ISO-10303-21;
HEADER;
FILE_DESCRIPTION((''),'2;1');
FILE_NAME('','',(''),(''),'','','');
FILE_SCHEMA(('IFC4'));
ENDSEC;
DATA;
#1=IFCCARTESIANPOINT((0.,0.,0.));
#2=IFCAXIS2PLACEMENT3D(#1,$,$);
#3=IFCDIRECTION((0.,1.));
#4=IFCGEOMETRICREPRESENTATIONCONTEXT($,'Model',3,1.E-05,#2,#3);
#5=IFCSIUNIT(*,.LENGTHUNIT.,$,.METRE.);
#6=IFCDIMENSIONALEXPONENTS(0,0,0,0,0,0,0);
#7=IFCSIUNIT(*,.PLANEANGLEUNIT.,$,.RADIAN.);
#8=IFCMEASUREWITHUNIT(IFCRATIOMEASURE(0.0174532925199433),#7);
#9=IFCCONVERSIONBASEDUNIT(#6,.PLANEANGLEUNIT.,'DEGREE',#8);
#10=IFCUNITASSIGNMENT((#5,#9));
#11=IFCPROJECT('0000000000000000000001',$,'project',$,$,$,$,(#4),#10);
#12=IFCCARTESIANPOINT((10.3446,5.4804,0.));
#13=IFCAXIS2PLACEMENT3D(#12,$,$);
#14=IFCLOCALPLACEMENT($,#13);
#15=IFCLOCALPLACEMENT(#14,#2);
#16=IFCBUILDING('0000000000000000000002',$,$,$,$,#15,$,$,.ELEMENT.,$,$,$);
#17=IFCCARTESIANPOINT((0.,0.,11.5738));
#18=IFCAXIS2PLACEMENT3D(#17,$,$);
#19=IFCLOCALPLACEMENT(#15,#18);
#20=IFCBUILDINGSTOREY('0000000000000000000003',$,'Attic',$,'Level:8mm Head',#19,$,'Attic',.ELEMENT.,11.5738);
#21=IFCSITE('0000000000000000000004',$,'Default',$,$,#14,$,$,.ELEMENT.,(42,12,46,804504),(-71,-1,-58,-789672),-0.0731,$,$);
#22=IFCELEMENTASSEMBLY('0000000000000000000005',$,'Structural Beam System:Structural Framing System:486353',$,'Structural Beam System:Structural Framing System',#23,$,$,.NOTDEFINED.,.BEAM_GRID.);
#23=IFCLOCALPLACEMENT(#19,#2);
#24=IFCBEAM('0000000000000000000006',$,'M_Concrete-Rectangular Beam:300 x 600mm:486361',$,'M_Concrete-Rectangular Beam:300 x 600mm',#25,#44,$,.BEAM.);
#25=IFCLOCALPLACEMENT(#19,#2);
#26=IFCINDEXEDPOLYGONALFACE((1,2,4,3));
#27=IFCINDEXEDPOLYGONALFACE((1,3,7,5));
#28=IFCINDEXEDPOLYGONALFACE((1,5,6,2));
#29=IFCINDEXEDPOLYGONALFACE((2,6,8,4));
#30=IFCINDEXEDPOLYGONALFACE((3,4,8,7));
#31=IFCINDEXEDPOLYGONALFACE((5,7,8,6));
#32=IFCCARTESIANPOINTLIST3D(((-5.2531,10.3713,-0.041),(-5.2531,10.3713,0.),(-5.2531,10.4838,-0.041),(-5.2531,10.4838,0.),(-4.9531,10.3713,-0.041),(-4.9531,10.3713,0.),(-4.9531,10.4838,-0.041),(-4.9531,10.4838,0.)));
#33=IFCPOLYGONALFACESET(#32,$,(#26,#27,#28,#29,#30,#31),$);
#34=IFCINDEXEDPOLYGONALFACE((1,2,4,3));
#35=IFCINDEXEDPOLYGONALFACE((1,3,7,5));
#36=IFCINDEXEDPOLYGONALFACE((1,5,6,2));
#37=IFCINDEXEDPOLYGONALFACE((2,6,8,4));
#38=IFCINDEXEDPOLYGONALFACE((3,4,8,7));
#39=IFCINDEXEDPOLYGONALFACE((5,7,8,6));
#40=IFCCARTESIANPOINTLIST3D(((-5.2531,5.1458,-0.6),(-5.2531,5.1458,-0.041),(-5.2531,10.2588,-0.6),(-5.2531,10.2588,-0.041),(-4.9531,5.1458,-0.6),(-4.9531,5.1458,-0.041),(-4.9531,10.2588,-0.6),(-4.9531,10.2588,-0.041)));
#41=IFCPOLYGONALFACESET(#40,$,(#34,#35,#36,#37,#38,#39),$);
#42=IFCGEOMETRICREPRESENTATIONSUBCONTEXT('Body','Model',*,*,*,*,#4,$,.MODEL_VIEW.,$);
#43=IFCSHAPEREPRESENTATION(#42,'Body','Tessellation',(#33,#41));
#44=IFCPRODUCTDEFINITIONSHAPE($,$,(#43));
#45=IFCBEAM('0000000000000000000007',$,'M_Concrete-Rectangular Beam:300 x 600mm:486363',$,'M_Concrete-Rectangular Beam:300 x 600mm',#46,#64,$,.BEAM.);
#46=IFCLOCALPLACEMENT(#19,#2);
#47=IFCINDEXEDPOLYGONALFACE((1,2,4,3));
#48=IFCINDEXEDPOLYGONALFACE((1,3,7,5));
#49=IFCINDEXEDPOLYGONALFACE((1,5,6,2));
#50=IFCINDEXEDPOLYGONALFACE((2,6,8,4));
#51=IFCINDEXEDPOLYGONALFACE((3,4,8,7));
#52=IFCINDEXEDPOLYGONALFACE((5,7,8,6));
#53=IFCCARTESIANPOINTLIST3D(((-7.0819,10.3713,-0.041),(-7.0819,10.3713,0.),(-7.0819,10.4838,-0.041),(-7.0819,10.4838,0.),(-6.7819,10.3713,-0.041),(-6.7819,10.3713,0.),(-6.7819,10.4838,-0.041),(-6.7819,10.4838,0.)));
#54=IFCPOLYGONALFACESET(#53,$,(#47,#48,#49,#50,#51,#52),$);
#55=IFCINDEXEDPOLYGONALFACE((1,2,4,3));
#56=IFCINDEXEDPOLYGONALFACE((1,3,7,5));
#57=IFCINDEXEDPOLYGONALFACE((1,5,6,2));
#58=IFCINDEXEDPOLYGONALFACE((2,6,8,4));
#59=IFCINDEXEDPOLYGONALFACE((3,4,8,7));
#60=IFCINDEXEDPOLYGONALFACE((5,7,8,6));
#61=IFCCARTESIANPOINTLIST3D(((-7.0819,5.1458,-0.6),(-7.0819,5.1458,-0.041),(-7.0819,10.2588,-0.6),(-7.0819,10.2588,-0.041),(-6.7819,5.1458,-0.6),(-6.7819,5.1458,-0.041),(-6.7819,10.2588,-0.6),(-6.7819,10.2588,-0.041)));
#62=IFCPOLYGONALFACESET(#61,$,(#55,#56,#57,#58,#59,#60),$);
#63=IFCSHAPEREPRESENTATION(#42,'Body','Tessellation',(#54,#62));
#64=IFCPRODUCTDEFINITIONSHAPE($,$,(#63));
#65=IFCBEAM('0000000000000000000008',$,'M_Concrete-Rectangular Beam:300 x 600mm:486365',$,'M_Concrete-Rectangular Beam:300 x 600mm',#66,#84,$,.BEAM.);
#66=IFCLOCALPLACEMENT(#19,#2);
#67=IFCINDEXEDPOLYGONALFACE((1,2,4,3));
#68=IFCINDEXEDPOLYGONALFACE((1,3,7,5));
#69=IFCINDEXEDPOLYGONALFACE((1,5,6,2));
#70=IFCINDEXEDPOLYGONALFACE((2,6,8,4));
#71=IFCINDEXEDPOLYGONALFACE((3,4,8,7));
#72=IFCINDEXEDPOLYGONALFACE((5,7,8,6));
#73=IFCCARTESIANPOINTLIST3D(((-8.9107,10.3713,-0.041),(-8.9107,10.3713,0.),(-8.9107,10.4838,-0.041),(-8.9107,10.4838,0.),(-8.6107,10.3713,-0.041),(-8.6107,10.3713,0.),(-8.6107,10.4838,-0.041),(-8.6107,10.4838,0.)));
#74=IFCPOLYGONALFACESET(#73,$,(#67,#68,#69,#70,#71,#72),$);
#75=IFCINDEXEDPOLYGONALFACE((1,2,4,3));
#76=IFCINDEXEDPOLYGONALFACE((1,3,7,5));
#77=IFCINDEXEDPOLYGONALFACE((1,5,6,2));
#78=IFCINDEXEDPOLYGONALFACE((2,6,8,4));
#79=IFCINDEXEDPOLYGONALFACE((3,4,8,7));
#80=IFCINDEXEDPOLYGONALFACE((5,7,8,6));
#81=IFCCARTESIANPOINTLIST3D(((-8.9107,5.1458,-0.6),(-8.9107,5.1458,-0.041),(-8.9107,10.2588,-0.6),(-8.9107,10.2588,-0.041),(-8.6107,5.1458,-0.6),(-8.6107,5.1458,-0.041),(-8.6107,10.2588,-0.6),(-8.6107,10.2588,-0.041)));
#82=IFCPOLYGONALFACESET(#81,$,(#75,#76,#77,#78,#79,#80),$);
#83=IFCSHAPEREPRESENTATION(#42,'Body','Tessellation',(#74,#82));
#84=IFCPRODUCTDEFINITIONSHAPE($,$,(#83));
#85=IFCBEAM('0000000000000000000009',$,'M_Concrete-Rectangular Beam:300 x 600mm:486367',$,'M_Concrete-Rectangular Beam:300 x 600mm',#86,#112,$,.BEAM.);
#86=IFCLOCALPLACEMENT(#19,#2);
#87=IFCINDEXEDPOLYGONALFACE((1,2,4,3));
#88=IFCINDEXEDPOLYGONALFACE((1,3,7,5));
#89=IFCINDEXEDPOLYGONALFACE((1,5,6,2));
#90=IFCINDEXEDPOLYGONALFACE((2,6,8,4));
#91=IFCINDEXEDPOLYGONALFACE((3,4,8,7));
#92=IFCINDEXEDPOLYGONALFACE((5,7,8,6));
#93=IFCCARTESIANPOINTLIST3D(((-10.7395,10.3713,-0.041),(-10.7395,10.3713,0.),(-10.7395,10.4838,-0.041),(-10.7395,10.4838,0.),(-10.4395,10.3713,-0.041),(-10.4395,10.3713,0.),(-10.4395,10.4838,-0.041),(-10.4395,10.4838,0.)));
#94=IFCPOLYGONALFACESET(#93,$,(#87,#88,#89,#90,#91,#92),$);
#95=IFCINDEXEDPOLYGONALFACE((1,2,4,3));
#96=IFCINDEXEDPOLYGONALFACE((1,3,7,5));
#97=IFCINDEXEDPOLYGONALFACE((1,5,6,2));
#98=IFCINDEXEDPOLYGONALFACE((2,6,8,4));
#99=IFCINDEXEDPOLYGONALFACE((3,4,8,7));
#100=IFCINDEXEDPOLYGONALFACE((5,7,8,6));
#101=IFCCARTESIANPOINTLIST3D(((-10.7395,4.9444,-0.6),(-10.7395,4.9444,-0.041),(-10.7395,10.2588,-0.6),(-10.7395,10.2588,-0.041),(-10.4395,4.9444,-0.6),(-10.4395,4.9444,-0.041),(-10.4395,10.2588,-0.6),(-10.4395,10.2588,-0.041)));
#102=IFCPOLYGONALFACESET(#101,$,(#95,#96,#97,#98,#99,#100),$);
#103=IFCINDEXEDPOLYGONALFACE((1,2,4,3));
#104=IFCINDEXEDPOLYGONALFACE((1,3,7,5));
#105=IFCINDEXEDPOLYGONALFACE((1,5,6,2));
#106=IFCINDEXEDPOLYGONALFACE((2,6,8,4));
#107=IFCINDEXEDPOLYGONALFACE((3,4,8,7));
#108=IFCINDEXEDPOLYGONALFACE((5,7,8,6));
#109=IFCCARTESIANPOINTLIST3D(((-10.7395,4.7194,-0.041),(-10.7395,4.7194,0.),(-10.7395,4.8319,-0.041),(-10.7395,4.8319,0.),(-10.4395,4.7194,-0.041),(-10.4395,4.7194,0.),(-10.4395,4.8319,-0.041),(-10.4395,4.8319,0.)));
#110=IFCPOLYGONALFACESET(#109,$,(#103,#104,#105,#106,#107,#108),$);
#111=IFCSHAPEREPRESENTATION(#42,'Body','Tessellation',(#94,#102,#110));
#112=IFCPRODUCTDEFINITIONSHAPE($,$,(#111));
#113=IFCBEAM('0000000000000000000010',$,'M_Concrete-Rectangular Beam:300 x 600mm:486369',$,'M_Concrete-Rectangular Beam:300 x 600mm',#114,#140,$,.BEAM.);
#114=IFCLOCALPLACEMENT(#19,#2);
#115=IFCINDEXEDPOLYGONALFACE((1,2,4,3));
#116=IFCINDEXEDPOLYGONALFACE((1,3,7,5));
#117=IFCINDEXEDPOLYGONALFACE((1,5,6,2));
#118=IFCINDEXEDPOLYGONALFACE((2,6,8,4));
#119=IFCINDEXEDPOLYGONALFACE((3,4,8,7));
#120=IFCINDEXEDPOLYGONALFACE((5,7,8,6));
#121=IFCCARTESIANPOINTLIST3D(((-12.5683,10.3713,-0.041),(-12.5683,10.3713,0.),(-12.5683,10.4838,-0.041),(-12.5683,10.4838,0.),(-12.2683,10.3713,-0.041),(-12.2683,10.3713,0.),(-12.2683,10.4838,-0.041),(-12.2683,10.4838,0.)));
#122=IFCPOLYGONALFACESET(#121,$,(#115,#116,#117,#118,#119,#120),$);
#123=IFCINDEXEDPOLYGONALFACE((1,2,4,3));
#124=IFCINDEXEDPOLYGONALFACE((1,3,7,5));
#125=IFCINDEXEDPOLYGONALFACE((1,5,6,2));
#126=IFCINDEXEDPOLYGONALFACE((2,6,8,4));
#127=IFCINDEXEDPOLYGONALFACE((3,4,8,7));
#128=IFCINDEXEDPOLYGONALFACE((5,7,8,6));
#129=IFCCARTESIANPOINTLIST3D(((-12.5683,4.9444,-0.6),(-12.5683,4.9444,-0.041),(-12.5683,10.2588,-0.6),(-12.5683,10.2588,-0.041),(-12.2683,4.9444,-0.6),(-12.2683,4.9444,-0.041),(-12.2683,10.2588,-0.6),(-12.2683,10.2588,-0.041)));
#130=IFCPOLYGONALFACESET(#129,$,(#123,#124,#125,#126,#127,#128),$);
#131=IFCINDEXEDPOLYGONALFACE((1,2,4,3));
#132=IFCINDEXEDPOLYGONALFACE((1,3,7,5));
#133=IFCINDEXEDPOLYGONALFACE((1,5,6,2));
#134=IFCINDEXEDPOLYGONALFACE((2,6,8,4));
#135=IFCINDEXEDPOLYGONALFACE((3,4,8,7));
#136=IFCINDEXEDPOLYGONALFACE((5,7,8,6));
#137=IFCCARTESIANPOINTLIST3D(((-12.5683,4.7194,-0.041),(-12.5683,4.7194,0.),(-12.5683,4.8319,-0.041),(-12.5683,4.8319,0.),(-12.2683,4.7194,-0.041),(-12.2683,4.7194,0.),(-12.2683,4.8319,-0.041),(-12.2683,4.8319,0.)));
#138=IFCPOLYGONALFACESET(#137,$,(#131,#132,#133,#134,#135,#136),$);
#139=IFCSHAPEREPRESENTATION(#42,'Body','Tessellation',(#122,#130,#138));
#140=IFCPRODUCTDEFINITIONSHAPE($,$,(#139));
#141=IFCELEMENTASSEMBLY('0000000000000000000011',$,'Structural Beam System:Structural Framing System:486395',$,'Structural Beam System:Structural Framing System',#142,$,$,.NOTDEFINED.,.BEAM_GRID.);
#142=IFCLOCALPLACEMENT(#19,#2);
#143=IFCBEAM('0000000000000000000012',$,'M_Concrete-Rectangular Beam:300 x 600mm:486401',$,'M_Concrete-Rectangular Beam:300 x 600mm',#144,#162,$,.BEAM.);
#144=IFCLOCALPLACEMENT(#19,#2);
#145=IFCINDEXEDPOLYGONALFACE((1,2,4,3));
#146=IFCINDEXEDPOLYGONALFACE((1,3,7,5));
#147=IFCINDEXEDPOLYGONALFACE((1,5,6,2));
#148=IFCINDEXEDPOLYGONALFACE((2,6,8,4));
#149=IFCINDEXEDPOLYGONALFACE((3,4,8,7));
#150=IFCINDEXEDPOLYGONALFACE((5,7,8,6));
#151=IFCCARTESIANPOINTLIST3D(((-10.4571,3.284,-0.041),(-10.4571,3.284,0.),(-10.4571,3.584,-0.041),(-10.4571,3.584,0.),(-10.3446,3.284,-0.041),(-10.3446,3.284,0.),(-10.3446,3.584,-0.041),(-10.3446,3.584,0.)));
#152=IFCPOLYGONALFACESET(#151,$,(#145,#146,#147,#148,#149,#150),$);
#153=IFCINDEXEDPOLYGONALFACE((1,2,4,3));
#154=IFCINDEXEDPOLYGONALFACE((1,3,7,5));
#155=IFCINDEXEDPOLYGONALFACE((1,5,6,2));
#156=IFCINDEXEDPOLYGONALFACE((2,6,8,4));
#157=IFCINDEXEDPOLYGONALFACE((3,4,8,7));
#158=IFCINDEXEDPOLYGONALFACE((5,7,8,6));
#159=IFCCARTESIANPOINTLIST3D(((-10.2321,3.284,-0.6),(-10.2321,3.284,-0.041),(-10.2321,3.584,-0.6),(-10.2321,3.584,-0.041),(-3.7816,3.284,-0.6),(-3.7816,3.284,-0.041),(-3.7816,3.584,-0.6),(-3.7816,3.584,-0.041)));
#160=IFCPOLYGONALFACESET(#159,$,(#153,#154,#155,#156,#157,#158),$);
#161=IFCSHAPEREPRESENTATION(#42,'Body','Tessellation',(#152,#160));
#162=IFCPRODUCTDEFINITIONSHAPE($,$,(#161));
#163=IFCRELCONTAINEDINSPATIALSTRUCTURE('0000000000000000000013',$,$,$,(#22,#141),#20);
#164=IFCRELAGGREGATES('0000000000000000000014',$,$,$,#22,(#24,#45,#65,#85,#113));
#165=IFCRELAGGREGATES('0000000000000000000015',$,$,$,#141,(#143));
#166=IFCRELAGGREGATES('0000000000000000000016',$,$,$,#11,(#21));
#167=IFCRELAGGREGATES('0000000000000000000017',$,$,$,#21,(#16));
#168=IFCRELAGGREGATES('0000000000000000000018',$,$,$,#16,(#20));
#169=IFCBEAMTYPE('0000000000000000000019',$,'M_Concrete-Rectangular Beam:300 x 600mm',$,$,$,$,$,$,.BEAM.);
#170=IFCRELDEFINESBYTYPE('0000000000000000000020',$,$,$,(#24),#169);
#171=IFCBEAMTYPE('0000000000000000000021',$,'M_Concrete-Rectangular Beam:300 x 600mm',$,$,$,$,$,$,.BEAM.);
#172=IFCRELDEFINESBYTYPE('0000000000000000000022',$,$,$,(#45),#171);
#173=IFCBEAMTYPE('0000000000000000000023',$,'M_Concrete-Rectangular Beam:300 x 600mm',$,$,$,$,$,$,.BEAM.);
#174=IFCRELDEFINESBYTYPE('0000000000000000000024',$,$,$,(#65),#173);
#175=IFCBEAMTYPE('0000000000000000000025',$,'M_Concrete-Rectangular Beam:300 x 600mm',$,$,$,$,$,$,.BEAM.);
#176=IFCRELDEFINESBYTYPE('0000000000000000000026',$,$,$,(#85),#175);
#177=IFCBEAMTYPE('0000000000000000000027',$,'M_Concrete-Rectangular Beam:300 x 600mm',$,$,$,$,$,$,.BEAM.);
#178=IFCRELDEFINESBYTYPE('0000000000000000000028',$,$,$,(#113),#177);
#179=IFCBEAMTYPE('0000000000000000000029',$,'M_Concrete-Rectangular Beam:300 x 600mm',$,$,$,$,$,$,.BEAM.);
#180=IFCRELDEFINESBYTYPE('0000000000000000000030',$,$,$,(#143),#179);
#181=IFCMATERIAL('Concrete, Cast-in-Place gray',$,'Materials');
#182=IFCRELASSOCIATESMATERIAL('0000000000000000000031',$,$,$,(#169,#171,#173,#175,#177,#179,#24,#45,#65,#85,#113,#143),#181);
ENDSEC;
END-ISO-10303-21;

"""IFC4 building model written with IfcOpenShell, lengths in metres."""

from ifc_helpers import new_model, entity, si_unit, converted_unit, direction, frame, frame_2d, origin, place, context, subcontext, project, spatial, rectangle, extrude, source, transform, mapped, material, material_profile, profile_set, profile_usage, type_object, type_shapes, element, aggregate, save


model = new_model("IFC4")

# Units and contexts
model_context = context("Model", 3, precision=1e-05, world=origin(), true_north=direction((0.0, 1.0)))
body_context = subcontext(model_context, "Body", "Model", "MODEL_VIEW")
ifc_project = project(units=[si_unit("LENGTHUNIT", "METRE"), converted_unit("PLANEANGLEUNIT", "DEGREE", entity("IfcRatioMeasure", 0.0174532925199433), si_unit("PLANEANGLEUNIT", "RADIAN"), dimensions=[0, 0, 0, 0, 0, 0, 0])], contexts=[model_context])

# Site, building, storey
site_placement = place(None, frame((10.3446, 5.4804, 0.0)))
site = spatial("IfcSite", under=ifc_project, at=site_placement, Name="Default", CompositionType="ELEMENT", RefLatitude=(42, 12, 46, 804504), RefLongitude=(-71, -1, -58, -789672), RefElevation=-0.0731)
building_placement = place(site_placement, origin())
building = spatial("IfcBuilding", under=site, at=building_placement, CompositionType="ELEMENT")
storey_placement = place(building_placement, frame((0.0, 0.0, 11.5738)))
storey = spatial("IfcBuildingStorey", under=building, at=storey_placement, Name="Attic", ObjectType="Level:8mm Head", LongName="Attic", CompositionType="ELEMENT", Elevation=11.5738)

# Element assemblies, beams
assembly_1_placement = place(storey_placement, origin())
assembly_1 = element("IfcElementAssembly", 1, at=assembly_1_placement, inside=storey, Name="Structural Beam System:Structural Framing System:486353", ObjectType="Structural Beam System:Structural Framing System", AssemblyPlace="NOTDEFINED", PredefinedType="BEAM_GRID")
ifc_material_1 = material(Name="Concrete, Cast-in-Place gray", Category="Materials")
ifc_material_profile = material_profile(ifc_material_1, rectangle(XDim=0.559, YDim=0.3, at=frame_2d((0.0, 0.0), x_axis=(1.0, 0.0))), Name="300 x 600mm")
ifc_profile_set = profile_set([ifc_material_profile], Name="300 x 600mm")
ifc_profile_usage_1 = profile_usage(ifc_profile_set, cardinal=8)
beam_type_1 = type_object("IfcBeamType", Name="M_Concrete-Rectangular Beam:300 x 600mm", PredefinedType="BEAM", material=ifc_profile_set)
shared_shape_1 = source(origin(), body_context, "Body", "SweptSolid", [
    extrude(rectangle(XDim=0.041, YDim=0.3, at=frame_2d((0.0, 0.0), x_axis=(0.0, 1.0))), frame((-5.1031, 10.4838, 11.5533), z_axis=(0.0, -1.0, 0.0), x_axis=(-1.0, 0.0, 0.0)), (0.0, 0.0, 1.0), 0.1125),
    extrude(rectangle(XDim=0.559, YDim=0.3, at=frame_2d((0.0, 0.0), x_axis=(0.0, 1.0))), frame((-5.1031, 10.2588, 11.2533), z_axis=(0.0, -1.0, 0.0), x_axis=(-1.0, 0.0, 0.0)), (0.0, 0.0, 1.0), 5.113),
])
type_shapes(beam_type_1, [shared_shape_1])
beam_1_placement = place(assembly_1_placement, frame((0.0, 0.0, -11.5738)))
beam_1 = element("IfcBeam", 2, at=beam_1_placement, type_object=beam_type_1, material=ifc_profile_usage_1, Name="M_Concrete-Rectangular Beam:300 x 600mm:486361", ObjectType="M_Concrete-Rectangular Beam:300 x 600mm", PredefinedType="BEAM", context=body_context, shape_type="MappedRepresentation", body=[
    mapped(shared_shape_1, transform((0.0, 0.0, 0.0), scale=1.0)),
])
ifc_profile_usage_2 = profile_usage(ifc_profile_set, cardinal=8)
beam_type_2 = type_object("IfcBeamType", Name="M_Concrete-Rectangular Beam:300 x 600mm", PredefinedType="BEAM", material=ifc_profile_set)
shared_shape_2 = source(origin(), body_context, "Body", "SweptSolid", [
    extrude(rectangle(XDim=0.041, YDim=0.3, at=frame_2d((0.0, 0.0), x_axis=(0.0, 1.0))), frame((-6.9319, 10.4838, 11.5533), z_axis=(0.0, -1.0, 0.0), x_axis=(-1.0, 0.0, 0.0)), (0.0, 0.0, 1.0), 0.1125),
    extrude(rectangle(XDim=0.559, YDim=0.3, at=frame_2d((0.0, 0.0), x_axis=(0.0, 1.0))), frame((-6.9319, 10.2588, 11.2533), z_axis=(0.0, -1.0, 0.0), x_axis=(-1.0, 0.0, 0.0)), (0.0, 0.0, 1.0), 5.113),
])
type_shapes(beam_type_2, [shared_shape_2])
beam_2_placement = place(assembly_1_placement, frame((0.0, 0.0, -11.5738)))
beam_2 = element("IfcBeam", 3, at=beam_2_placement, type_object=beam_type_2, material=ifc_profile_usage_2, Name="M_Concrete-Rectangular Beam:300 x 600mm:486363", ObjectType="M_Concrete-Rectangular Beam:300 x 600mm", PredefinedType="BEAM", context=body_context, shape_type="MappedRepresentation", body=[
    mapped(shared_shape_2, transform((0.0, 0.0, 0.0), scale=1.0)),
])
ifc_profile_usage_3 = profile_usage(ifc_profile_set, cardinal=8)
beam_type_3 = type_object("IfcBeamType", Name="M_Concrete-Rectangular Beam:300 x 600mm", PredefinedType="BEAM", material=ifc_profile_set)
shared_shape_3 = source(origin(), body_context, "Body", "SweptSolid", [
    extrude(rectangle(XDim=0.041, YDim=0.3, at=frame_2d((0.0, 0.0), x_axis=(0.0, 1.0))), frame((-8.7607, 10.4838, 11.5533), z_axis=(0.0, -1.0, 0.0), x_axis=(-1.0, 0.0, 0.0)), (0.0, 0.0, 1.0), 0.1125),
    extrude(rectangle(XDim=0.559, YDim=0.3, at=frame_2d((0.0, 0.0), x_axis=(0.0, 1.0))), frame((-8.7607, 10.2588, 11.2533), z_axis=(0.0, -1.0, 0.0), x_axis=(-1.0, 0.0, 0.0)), (0.0, 0.0, 1.0), 5.113),
])
type_shapes(beam_type_3, [shared_shape_3])
beam_3_placement = place(assembly_1_placement, frame((0.0, 0.0, -11.5738)))
beam_3 = element("IfcBeam", 4, at=beam_3_placement, type_object=beam_type_3, material=ifc_profile_usage_3, Name="M_Concrete-Rectangular Beam:300 x 600mm:486365", ObjectType="M_Concrete-Rectangular Beam:300 x 600mm", PredefinedType="BEAM", context=body_context, shape_type="MappedRepresentation", body=[
    mapped(shared_shape_3, transform((0.0, 0.0, 0.0), scale=1.0)),
])
ifc_profile_usage_4 = profile_usage(ifc_profile_set, cardinal=8)
beam_type_4 = type_object("IfcBeamType", Name="M_Concrete-Rectangular Beam:300 x 600mm", PredefinedType="BEAM", material=ifc_profile_set)
shared_shape_4 = source(origin(), body_context, "Body", "SweptSolid", [
    extrude(rectangle(XDim=0.041, YDim=0.3, at=frame_2d((0.0, 0.0), x_axis=(0.0, 1.0))), frame((-10.5895, 10.4838, 11.5533), z_axis=(0.0, -1.0, 0.0), x_axis=(-1.0, 0.0, 0.0)), (0.0, 0.0, 1.0), 0.1125),
    extrude(rectangle(XDim=0.559, YDim=0.3, at=frame_2d((0.0, 0.0), x_axis=(0.0, 1.0))), frame((-10.5895, 10.2588, 11.2533), z_axis=(0.0, -1.0, 0.0), x_axis=(-1.0, 0.0, 0.0)), (0.0, 0.0, 1.0), 5.3144),
    extrude(rectangle(XDim=0.041, YDim=0.3, at=frame_2d((0.0, 0.0), x_axis=(0.0, 1.0))), frame((-10.5895, 4.8319, 11.5533), z_axis=(0.0, -1.0, 0.0), x_axis=(-1.0, 0.0, 0.0)), (0.0, 0.0, 1.0), 0.1125),
])
type_shapes(beam_type_4, [shared_shape_4])
beam_4_placement = place(assembly_1_placement, frame((0.0, 0.0, -11.5738)))
beam_4 = element("IfcBeam", 5, at=beam_4_placement, type_object=beam_type_4, material=ifc_profile_usage_4, Name="M_Concrete-Rectangular Beam:300 x 600mm:486367", ObjectType="M_Concrete-Rectangular Beam:300 x 600mm", PredefinedType="BEAM", context=body_context, shape_type="MappedRepresentation", body=[
    mapped(shared_shape_4, transform((0.0, 0.0, 0.0), scale=1.0)),
])
ifc_profile_usage_5 = profile_usage(ifc_profile_set, cardinal=8)
beam_type_5 = type_object("IfcBeamType", Name="M_Concrete-Rectangular Beam:300 x 600mm", PredefinedType="BEAM", material=ifc_profile_set)
shared_shape_5 = source(origin(), body_context, "Body", "SweptSolid", [
    extrude(rectangle(XDim=0.041, YDim=0.3, at=frame_2d((0.0, 0.0), x_axis=(0.0, 1.0))), frame((-12.4183, 10.4838, 11.5533), z_axis=(0.0, -1.0, 0.0), x_axis=(-1.0, 0.0, 0.0)), (0.0, 0.0, 1.0), 0.1125),
    extrude(rectangle(XDim=0.559, YDim=0.3, at=frame_2d((0.0, 0.0), x_axis=(0.0, 1.0))), frame((-12.4183, 10.2588, 11.2533), z_axis=(0.0, -1.0, 0.0), x_axis=(-1.0, 0.0, 0.0)), (0.0, 0.0, 1.0), 5.3144),
    extrude(rectangle(XDim=0.041, YDim=0.3, at=frame_2d((0.0, 0.0), x_axis=(0.0, 1.0))), frame((-12.4183, 4.8319, 11.5533), z_axis=(0.0, -1.0, 0.0), x_axis=(-1.0, 0.0, 0.0)), (0.0, 0.0, 1.0), 0.1125),
])
type_shapes(beam_type_5, [shared_shape_5])
beam_5_placement = place(assembly_1_placement, frame((0.0, 0.0, -11.5738)))
beam_5 = element("IfcBeam", 6, at=beam_5_placement, type_object=beam_type_5, material=ifc_profile_usage_5, Name="M_Concrete-Rectangular Beam:300 x 600mm:486369", ObjectType="M_Concrete-Rectangular Beam:300 x 600mm", PredefinedType="BEAM", context=body_context, shape_type="MappedRepresentation", body=[
    mapped(shared_shape_5, transform((0.0, 0.0, 0.0), scale=1.0)),
])
aggregate(assembly_1, [beam_1, beam_2, beam_3, beam_4, beam_5])
assembly_2_placement = place(storey_placement, origin())
assembly_2 = element("IfcElementAssembly", 7, at=assembly_2_placement, inside=storey, Name="Structural Beam System:Structural Framing System:486395", ObjectType="Structural Beam System:Structural Framing System", AssemblyPlace="NOTDEFINED", PredefinedType="BEAM_GRID")
ifc_profile_usage_6 = profile_usage(ifc_profile_set, cardinal=8)
beam_type_6 = type_object("IfcBeamType", Name="M_Concrete-Rectangular Beam:300 x 600mm", PredefinedType="BEAM", material=ifc_profile_set)
shared_shape_6 = source(origin(), body_context, "Body", "SweptSolid", [
    extrude(rectangle(XDim=0.041, YDim=0.3, at=frame_2d((0.0, 0.0), x_axis=(1.0, 0.0))), frame((-10.4571, 3.434, 11.5533), z_axis=(1.0, 0.0, 0.0), x_axis=(0.0, 0.0, -1.0)), (0.0, 0.0, 1.0), 0.1125),
    extrude(rectangle(XDim=0.559, YDim=0.3, at=frame_2d((0.0, 0.0), x_axis=(1.0, 0.0))), frame((-10.2321, 3.434, 11.2533), z_axis=(1.0, 0.0, 0.0), x_axis=(0.0, 0.0, -1.0)), (0.0, 0.0, 1.0), 6.4506),
])
type_shapes(beam_type_6, [shared_shape_6])
beam_6_placement = place(assembly_2_placement, frame((0.0, 0.0, -11.5738)))
beam_6 = element("IfcBeam", 8, at=beam_6_placement, type_object=beam_type_6, material=ifc_profile_usage_6, Name="M_Concrete-Rectangular Beam:300 x 600mm:486401", ObjectType="M_Concrete-Rectangular Beam:300 x 600mm", PredefinedType="BEAM", context=body_context, shape_type="MappedRepresentation", body=[
    mapped(shared_shape_6, transform((0.0, 0.0, 0.0), scale=1.0)),
])
aggregate(assembly_2, [beam_6])

save(model, "model.ifc")
